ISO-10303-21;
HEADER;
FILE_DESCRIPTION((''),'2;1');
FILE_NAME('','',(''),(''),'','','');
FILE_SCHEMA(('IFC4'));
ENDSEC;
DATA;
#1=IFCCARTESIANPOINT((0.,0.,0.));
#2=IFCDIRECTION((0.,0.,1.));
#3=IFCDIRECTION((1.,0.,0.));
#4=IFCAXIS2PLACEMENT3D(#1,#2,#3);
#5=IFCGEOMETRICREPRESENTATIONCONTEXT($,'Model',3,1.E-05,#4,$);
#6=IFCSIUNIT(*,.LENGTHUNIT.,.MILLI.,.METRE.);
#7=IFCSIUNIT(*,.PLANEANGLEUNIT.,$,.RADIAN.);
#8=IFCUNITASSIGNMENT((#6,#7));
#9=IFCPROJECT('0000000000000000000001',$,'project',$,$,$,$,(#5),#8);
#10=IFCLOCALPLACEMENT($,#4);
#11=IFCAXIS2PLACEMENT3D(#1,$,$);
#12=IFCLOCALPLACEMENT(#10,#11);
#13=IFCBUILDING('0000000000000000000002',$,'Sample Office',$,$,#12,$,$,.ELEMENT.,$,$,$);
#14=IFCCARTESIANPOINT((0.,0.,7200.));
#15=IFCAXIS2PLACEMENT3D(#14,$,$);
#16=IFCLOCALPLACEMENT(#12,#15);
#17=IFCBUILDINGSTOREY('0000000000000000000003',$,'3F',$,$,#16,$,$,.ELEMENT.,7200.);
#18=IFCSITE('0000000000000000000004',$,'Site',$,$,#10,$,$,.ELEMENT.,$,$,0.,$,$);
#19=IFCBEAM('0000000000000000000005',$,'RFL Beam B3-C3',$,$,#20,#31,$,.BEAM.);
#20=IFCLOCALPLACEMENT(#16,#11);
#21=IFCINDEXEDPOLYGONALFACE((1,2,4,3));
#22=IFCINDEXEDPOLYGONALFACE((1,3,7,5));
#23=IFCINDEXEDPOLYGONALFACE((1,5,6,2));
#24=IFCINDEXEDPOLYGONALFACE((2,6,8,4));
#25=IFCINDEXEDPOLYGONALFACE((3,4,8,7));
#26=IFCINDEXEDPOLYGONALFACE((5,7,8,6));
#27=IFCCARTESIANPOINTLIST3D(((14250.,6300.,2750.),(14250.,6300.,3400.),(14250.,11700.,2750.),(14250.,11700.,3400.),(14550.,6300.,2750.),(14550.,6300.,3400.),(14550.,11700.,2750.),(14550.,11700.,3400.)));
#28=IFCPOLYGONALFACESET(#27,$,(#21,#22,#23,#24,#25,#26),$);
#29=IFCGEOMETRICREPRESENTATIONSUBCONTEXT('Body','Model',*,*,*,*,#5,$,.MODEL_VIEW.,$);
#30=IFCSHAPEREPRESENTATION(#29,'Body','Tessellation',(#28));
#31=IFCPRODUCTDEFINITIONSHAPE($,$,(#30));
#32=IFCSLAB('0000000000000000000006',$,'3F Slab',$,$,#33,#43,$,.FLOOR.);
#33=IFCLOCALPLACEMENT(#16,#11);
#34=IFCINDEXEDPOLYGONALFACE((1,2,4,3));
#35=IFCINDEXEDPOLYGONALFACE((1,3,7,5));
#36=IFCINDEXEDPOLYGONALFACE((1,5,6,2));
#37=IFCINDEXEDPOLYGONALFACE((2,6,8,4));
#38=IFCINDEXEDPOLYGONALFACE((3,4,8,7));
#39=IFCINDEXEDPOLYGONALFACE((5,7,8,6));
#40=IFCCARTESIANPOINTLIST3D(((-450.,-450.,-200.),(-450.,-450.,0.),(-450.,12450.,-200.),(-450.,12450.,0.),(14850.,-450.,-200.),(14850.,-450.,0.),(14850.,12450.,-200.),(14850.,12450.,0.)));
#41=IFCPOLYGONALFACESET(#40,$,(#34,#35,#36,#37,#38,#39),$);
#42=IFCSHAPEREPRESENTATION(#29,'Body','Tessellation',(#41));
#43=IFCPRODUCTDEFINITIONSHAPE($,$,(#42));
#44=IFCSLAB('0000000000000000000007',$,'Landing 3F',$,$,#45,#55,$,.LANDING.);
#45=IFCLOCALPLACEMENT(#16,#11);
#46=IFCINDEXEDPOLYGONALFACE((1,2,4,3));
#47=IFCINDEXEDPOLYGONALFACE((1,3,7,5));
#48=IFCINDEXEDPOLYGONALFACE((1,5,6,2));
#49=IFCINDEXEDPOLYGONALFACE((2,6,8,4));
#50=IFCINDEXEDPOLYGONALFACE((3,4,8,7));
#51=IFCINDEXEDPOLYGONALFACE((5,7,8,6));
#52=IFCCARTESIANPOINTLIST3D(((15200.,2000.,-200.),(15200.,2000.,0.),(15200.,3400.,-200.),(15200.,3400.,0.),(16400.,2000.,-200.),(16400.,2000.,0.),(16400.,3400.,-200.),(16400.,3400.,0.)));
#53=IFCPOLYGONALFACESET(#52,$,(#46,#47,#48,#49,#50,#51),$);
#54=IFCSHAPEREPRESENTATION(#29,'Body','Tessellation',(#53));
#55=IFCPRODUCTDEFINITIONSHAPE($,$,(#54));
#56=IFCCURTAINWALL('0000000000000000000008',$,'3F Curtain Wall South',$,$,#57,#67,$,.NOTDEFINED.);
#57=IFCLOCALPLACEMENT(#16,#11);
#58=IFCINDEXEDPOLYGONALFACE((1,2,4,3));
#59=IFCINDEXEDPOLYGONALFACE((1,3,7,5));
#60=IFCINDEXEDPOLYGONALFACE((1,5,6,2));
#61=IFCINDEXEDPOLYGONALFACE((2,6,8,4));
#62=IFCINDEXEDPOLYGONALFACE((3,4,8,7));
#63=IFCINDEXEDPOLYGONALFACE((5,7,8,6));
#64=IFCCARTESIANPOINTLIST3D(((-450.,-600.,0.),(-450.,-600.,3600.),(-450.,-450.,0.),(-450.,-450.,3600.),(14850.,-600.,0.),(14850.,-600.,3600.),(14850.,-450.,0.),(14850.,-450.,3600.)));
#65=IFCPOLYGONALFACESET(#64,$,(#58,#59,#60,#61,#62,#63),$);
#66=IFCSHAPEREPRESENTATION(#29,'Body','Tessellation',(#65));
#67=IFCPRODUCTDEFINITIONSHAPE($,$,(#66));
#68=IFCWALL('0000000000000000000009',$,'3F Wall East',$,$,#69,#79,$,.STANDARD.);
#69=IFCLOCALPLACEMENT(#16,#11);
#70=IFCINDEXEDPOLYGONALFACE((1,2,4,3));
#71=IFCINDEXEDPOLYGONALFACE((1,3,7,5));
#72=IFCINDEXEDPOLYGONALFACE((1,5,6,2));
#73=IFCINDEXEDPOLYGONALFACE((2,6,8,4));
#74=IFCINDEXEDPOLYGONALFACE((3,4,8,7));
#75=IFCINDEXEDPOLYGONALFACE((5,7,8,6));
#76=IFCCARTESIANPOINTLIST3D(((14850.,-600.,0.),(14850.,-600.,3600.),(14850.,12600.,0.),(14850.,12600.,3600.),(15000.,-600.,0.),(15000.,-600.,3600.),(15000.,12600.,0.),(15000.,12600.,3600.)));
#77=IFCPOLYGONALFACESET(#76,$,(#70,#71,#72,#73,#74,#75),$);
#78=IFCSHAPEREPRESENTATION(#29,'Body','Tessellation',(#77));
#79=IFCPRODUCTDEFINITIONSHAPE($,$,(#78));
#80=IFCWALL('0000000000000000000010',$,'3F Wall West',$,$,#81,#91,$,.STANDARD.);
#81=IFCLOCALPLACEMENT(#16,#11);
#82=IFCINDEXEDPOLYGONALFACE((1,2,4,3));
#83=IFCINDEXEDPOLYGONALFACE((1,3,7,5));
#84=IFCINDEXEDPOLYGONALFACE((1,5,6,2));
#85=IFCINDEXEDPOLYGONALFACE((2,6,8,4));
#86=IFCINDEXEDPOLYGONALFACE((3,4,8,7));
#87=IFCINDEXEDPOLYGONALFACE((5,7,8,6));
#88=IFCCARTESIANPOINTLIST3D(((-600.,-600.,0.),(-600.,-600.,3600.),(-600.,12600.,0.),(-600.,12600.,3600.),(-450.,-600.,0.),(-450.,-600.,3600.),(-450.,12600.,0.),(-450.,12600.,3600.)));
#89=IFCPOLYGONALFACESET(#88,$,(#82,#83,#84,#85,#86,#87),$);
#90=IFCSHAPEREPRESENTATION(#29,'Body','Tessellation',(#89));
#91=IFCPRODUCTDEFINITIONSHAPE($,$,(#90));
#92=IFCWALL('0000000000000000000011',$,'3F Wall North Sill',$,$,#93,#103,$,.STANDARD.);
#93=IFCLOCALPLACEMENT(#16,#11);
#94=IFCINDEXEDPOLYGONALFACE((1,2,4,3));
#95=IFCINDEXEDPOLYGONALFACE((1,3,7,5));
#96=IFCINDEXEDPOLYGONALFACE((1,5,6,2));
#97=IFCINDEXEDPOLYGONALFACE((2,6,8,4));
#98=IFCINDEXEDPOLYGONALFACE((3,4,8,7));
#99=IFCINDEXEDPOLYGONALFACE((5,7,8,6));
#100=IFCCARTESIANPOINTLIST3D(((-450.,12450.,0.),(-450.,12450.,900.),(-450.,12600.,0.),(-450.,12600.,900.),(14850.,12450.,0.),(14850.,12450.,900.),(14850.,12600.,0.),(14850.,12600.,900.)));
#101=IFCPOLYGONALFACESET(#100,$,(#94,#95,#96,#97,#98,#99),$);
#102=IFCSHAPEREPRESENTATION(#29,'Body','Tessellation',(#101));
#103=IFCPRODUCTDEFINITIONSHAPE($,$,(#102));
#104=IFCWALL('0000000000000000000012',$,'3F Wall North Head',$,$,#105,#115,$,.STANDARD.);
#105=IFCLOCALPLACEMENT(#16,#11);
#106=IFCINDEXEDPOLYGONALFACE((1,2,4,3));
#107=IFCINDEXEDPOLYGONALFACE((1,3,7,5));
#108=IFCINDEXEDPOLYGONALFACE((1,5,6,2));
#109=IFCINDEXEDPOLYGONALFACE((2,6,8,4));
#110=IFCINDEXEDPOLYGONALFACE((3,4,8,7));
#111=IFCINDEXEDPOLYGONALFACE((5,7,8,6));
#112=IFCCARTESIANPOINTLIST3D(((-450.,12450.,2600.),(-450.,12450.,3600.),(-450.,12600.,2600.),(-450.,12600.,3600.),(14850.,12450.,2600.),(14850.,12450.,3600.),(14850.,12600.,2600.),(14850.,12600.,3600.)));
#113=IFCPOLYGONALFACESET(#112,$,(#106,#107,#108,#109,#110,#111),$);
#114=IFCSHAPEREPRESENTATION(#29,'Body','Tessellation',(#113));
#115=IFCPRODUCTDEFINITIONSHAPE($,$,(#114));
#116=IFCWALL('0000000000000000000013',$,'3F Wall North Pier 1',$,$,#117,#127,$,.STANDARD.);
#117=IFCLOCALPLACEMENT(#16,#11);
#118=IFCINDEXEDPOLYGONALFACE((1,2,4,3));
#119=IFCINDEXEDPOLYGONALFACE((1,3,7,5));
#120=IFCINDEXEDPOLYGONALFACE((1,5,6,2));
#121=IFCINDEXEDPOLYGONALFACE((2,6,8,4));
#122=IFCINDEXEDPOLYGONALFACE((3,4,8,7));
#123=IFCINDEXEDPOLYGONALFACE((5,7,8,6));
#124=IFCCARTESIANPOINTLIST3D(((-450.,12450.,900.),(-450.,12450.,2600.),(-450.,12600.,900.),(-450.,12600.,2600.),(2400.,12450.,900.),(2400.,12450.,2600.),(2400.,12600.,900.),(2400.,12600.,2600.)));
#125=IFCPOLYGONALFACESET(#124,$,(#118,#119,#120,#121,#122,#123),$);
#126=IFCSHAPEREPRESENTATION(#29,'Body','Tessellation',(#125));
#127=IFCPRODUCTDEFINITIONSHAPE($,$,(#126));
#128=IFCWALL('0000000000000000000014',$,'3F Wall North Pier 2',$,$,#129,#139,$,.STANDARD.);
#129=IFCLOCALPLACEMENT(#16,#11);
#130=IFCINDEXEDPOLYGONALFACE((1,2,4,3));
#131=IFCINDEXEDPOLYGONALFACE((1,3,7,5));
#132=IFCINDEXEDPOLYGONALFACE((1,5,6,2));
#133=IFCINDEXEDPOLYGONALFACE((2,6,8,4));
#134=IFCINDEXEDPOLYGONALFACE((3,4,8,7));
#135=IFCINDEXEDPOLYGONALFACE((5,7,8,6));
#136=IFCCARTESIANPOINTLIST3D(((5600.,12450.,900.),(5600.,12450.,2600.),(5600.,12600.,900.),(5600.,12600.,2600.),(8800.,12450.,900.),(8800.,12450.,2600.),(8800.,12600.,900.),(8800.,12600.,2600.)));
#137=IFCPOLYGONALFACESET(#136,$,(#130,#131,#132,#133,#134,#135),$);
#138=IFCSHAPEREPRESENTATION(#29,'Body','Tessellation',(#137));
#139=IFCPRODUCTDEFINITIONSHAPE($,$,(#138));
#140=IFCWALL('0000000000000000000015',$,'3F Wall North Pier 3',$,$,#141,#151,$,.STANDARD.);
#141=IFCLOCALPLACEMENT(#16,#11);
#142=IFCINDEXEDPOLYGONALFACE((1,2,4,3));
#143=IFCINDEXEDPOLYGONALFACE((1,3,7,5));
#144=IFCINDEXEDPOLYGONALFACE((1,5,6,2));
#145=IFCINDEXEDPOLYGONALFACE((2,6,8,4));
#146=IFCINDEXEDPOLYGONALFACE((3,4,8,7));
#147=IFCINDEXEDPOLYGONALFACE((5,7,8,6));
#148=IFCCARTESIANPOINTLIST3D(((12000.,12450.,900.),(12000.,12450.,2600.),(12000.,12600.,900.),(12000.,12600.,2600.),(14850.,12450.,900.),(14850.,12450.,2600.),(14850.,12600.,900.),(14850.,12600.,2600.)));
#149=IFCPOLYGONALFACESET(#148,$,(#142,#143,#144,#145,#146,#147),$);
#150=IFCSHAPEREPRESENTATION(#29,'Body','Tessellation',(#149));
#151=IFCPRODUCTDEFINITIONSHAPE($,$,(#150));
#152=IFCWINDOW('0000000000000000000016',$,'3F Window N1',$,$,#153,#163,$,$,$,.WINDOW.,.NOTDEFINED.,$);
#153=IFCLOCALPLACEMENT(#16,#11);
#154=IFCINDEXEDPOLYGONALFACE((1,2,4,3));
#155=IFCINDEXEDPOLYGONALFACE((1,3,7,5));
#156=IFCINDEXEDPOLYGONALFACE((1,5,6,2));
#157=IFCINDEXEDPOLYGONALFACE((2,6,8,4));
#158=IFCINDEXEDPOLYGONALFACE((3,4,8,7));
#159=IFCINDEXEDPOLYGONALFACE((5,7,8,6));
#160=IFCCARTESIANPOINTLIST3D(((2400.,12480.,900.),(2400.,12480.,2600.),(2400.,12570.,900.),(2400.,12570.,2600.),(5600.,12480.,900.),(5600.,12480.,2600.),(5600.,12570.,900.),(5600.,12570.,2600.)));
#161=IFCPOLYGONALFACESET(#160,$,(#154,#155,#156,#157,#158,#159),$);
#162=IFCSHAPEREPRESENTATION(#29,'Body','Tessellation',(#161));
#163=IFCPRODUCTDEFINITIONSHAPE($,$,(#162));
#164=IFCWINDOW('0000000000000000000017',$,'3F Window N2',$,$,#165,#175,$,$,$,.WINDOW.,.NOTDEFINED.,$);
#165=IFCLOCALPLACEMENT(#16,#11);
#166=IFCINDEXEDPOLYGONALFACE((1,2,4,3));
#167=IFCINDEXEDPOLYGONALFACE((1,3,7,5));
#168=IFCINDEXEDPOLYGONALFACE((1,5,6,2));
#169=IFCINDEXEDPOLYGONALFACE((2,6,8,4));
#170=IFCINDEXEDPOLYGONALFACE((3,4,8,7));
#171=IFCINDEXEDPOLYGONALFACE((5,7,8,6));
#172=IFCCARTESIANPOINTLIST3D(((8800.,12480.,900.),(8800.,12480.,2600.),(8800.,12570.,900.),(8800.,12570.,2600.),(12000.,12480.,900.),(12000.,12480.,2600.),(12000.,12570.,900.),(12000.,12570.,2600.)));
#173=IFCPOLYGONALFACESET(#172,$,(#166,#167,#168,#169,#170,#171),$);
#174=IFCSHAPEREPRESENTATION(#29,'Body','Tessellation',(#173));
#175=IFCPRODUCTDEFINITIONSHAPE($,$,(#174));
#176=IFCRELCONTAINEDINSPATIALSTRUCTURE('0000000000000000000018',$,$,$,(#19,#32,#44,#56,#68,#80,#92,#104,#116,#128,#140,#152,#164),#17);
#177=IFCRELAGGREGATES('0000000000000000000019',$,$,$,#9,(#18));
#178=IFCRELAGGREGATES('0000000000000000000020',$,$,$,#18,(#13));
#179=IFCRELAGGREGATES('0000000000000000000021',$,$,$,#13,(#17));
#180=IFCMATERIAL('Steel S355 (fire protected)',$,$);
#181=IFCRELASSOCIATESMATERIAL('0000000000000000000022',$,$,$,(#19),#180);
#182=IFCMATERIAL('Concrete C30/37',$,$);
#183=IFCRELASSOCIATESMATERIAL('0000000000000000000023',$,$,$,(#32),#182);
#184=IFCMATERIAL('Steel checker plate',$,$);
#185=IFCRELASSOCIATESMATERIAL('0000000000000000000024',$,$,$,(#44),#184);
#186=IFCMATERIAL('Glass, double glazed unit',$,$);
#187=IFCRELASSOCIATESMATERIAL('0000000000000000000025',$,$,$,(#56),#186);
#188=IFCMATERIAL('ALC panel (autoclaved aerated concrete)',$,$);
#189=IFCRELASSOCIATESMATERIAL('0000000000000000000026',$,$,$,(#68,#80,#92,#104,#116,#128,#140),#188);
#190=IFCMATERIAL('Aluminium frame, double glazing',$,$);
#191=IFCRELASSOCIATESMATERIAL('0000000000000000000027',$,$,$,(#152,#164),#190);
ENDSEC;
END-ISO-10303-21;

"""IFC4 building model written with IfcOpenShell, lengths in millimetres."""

from ifc_helpers import new_model, si_unit, frame, origin, origin_with_axes, origin_2d, place, context, subcontext, project, spatial, rectangle, extrude, material, element, save


model = new_model("IFC4")

# Units and contexts
model_context = context("Model", 3, precision=1e-05, world=origin_with_axes())
body_context = subcontext(model_context, "Body", "Model", "MODEL_VIEW")
ifc_project = project(units=[si_unit("LENGTHUNIT", "METRE", prefix="MILLI"), si_unit("PLANEANGLEUNIT", "RADIAN")], contexts=[model_context])

# Site, building, storey
site_placement = place(None, origin_with_axes())
site = spatial("IfcSite", under=ifc_project, at=site_placement, Name="Site", CompositionType="ELEMENT", RefElevation=0.0)
building_placement = place(site_placement, origin())
building = spatial("IfcBuilding", under=site, at=building_placement, Name="Sample Office", CompositionType="ELEMENT")
storey_placement = place(building_placement, frame((0.0, 0.0, 7200.0)))
storey = spatial("IfcBuildingStorey", under=building, at=storey_placement, Name="3F", CompositionType="ELEMENT", Elevation=7200.0)

# Shared definitions
ifc_material_1 = material(Name="Concrete C30/37")

# Beam
ifc_material_2 = material(Name="Steel S355 (fire protected)")
for number, where, name in (
    (1, (14400.0, 9000.0, 2750.0), "RFL Beam B3-C3"),
):
    element("IfcBeam", number, at=place(storey_placement, frame(where)), inside=storey, material=ifc_material_2, Name=name, PredefinedType="BEAM", context=body_context, shape_type="SweptSolid", body=[
        extrude(rectangle(XDim=300.0, YDim=5400.0, at=origin_2d()), origin(), (0.0, 0.0, 1.0), 650.0),
    ])

# Slabs
slab_1_placement = place(storey_placement, frame((7200.0, 6000.0, -200.0)))
element("IfcSlab", 2, at=slab_1_placement, inside=storey, material=ifc_material_1, Name="3F Slab", PredefinedType="FLOOR", context=body_context, shape_type="SweptSolid", body=[
    extrude(rectangle(XDim=15300.0, YDim=12900.0, at=origin_2d()), origin(), (0.0, 0.0, 1.0), 200.0),
])
ifc_material_3 = material(Name="Steel checker plate")
slab_2_placement = place(storey_placement, frame((15800.0, 2700.0, -200.0)))
element("IfcSlab", 3, at=slab_2_placement, inside=storey, material=ifc_material_3, Name="Landing 3F", PredefinedType="LANDING", context=body_context, shape_type="SweptSolid", body=[
    extrude(rectangle(XDim=1200.0, YDim=1400.0, at=origin_2d()), origin(), (0.0, 0.0, 1.0), 200.0),
])

# Curtain wall
ifc_material_4 = material(Name="Glass, double glazed unit")
curtain_wall_placement = place(storey_placement, frame((7200.0, -525.0, 0.0)))
element("IfcCurtainWall", 4, at=curtain_wall_placement, inside=storey, material=ifc_material_4, Name="3F Curtain Wall South", PredefinedType="NOTDEFINED", context=body_context, shape_type="SweptSolid", body=[
    extrude(rectangle(XDim=15300.0, YDim=150.0, at=origin_2d()), origin(), (0.0, 0.0, 1.0), 3600.0),
])

# Walls
ifc_material_5 = material(Name="ALC panel (autoclaved aerated concrete)")
for number, where, name in (
    (5, (14925.0, 6000.0, 0.0), "3F Wall East"),
    (6, (-525.0, 6000.0, 0.0), "3F Wall West"),
):
    element("IfcWall", number, at=place(storey_placement, frame(where)), inside=storey, material=ifc_material_5, Name=name, PredefinedType="STANDARD", context=body_context, shape_type="SweptSolid", body=[
        extrude(rectangle(XDim=150.0, YDim=13200.0, at=origin_2d()), origin(), (0.0, 0.0, 1.0), 3600.0),
    ])
wall_1_placement = place(storey_placement, frame((7200.0, 12525.0, 0.0)))
element("IfcWall", 7, at=wall_1_placement, inside=storey, material=ifc_material_5, Name="3F Wall North Sill", PredefinedType="STANDARD", context=body_context, shape_type="SweptSolid", body=[
    extrude(rectangle(XDim=15300.0, YDim=150.0, at=origin_2d()), origin(), (0.0, 0.0, 1.0), 900.0),
])
wall_2_placement = place(storey_placement, frame((7200.0, 12525.0, 2600.0)))
element("IfcWall", 8, at=wall_2_placement, inside=storey, material=ifc_material_5, Name="3F Wall North Head", PredefinedType="STANDARD", context=body_context, shape_type="SweptSolid", body=[
    extrude(rectangle(XDim=15300.0, YDim=150.0, at=origin_2d()), origin(), (0.0, 0.0, 1.0), 1000.0),
])
wall_3_placement = place(storey_placement, frame((975.0, 12525.0, 900.0)))
element("IfcWall", 9, at=wall_3_placement, inside=storey, material=ifc_material_5, Name="3F Wall North Pier 1", PredefinedType="STANDARD", context=body_context, shape_type="SweptSolid", body=[
    extrude(rectangle(XDim=2850.0, YDim=150.0, at=origin_2d()), origin(), (0.0, 0.0, 1.0), 1700.0),
])
wall_4_placement = place(storey_placement, frame((7200.0, 12525.0, 900.0)))
element("IfcWall", 10, at=wall_4_placement, inside=storey, material=ifc_material_5, Name="3F Wall North Pier 2", PredefinedType="STANDARD", context=body_context, shape_type="SweptSolid", body=[
    extrude(rectangle(XDim=3200.0, YDim=150.0, at=origin_2d()), origin(), (0.0, 0.0, 1.0), 1700.0),
])
wall_5_placement = place(storey_placement, frame((13425.0, 12525.0, 900.0)))
element("IfcWall", 11, at=wall_5_placement, inside=storey, material=ifc_material_5, Name="3F Wall North Pier 3", PredefinedType="STANDARD", context=body_context, shape_type="SweptSolid", body=[
    extrude(rectangle(XDim=2850.0, YDim=150.0, at=origin_2d()), origin(), (0.0, 0.0, 1.0), 1700.0),
])

# Windows
ifc_material_6 = material(Name="Aluminium frame, double glazing")
for number, where, name in (
    (12, (4000.0, 12525.0, 900.0), "3F Window N1"),
    (13, (10400.0, 12525.0, 900.0), "3F Window N2"),
):
    element("IfcWindow", number, at=place(storey_placement, frame(where)), inside=storey, material=ifc_material_6, Name=name, PartitioningType="NOTDEFINED", PredefinedType="WINDOW", context=body_context, shape_type="SweptSolid", body=[
        extrude(rectangle(XDim=3200.0, YDim=90.0, at=origin_2d()), origin(), (0.0, 0.0, 1.0), 1700.0),
    ])

save(model, "model.ifc")
